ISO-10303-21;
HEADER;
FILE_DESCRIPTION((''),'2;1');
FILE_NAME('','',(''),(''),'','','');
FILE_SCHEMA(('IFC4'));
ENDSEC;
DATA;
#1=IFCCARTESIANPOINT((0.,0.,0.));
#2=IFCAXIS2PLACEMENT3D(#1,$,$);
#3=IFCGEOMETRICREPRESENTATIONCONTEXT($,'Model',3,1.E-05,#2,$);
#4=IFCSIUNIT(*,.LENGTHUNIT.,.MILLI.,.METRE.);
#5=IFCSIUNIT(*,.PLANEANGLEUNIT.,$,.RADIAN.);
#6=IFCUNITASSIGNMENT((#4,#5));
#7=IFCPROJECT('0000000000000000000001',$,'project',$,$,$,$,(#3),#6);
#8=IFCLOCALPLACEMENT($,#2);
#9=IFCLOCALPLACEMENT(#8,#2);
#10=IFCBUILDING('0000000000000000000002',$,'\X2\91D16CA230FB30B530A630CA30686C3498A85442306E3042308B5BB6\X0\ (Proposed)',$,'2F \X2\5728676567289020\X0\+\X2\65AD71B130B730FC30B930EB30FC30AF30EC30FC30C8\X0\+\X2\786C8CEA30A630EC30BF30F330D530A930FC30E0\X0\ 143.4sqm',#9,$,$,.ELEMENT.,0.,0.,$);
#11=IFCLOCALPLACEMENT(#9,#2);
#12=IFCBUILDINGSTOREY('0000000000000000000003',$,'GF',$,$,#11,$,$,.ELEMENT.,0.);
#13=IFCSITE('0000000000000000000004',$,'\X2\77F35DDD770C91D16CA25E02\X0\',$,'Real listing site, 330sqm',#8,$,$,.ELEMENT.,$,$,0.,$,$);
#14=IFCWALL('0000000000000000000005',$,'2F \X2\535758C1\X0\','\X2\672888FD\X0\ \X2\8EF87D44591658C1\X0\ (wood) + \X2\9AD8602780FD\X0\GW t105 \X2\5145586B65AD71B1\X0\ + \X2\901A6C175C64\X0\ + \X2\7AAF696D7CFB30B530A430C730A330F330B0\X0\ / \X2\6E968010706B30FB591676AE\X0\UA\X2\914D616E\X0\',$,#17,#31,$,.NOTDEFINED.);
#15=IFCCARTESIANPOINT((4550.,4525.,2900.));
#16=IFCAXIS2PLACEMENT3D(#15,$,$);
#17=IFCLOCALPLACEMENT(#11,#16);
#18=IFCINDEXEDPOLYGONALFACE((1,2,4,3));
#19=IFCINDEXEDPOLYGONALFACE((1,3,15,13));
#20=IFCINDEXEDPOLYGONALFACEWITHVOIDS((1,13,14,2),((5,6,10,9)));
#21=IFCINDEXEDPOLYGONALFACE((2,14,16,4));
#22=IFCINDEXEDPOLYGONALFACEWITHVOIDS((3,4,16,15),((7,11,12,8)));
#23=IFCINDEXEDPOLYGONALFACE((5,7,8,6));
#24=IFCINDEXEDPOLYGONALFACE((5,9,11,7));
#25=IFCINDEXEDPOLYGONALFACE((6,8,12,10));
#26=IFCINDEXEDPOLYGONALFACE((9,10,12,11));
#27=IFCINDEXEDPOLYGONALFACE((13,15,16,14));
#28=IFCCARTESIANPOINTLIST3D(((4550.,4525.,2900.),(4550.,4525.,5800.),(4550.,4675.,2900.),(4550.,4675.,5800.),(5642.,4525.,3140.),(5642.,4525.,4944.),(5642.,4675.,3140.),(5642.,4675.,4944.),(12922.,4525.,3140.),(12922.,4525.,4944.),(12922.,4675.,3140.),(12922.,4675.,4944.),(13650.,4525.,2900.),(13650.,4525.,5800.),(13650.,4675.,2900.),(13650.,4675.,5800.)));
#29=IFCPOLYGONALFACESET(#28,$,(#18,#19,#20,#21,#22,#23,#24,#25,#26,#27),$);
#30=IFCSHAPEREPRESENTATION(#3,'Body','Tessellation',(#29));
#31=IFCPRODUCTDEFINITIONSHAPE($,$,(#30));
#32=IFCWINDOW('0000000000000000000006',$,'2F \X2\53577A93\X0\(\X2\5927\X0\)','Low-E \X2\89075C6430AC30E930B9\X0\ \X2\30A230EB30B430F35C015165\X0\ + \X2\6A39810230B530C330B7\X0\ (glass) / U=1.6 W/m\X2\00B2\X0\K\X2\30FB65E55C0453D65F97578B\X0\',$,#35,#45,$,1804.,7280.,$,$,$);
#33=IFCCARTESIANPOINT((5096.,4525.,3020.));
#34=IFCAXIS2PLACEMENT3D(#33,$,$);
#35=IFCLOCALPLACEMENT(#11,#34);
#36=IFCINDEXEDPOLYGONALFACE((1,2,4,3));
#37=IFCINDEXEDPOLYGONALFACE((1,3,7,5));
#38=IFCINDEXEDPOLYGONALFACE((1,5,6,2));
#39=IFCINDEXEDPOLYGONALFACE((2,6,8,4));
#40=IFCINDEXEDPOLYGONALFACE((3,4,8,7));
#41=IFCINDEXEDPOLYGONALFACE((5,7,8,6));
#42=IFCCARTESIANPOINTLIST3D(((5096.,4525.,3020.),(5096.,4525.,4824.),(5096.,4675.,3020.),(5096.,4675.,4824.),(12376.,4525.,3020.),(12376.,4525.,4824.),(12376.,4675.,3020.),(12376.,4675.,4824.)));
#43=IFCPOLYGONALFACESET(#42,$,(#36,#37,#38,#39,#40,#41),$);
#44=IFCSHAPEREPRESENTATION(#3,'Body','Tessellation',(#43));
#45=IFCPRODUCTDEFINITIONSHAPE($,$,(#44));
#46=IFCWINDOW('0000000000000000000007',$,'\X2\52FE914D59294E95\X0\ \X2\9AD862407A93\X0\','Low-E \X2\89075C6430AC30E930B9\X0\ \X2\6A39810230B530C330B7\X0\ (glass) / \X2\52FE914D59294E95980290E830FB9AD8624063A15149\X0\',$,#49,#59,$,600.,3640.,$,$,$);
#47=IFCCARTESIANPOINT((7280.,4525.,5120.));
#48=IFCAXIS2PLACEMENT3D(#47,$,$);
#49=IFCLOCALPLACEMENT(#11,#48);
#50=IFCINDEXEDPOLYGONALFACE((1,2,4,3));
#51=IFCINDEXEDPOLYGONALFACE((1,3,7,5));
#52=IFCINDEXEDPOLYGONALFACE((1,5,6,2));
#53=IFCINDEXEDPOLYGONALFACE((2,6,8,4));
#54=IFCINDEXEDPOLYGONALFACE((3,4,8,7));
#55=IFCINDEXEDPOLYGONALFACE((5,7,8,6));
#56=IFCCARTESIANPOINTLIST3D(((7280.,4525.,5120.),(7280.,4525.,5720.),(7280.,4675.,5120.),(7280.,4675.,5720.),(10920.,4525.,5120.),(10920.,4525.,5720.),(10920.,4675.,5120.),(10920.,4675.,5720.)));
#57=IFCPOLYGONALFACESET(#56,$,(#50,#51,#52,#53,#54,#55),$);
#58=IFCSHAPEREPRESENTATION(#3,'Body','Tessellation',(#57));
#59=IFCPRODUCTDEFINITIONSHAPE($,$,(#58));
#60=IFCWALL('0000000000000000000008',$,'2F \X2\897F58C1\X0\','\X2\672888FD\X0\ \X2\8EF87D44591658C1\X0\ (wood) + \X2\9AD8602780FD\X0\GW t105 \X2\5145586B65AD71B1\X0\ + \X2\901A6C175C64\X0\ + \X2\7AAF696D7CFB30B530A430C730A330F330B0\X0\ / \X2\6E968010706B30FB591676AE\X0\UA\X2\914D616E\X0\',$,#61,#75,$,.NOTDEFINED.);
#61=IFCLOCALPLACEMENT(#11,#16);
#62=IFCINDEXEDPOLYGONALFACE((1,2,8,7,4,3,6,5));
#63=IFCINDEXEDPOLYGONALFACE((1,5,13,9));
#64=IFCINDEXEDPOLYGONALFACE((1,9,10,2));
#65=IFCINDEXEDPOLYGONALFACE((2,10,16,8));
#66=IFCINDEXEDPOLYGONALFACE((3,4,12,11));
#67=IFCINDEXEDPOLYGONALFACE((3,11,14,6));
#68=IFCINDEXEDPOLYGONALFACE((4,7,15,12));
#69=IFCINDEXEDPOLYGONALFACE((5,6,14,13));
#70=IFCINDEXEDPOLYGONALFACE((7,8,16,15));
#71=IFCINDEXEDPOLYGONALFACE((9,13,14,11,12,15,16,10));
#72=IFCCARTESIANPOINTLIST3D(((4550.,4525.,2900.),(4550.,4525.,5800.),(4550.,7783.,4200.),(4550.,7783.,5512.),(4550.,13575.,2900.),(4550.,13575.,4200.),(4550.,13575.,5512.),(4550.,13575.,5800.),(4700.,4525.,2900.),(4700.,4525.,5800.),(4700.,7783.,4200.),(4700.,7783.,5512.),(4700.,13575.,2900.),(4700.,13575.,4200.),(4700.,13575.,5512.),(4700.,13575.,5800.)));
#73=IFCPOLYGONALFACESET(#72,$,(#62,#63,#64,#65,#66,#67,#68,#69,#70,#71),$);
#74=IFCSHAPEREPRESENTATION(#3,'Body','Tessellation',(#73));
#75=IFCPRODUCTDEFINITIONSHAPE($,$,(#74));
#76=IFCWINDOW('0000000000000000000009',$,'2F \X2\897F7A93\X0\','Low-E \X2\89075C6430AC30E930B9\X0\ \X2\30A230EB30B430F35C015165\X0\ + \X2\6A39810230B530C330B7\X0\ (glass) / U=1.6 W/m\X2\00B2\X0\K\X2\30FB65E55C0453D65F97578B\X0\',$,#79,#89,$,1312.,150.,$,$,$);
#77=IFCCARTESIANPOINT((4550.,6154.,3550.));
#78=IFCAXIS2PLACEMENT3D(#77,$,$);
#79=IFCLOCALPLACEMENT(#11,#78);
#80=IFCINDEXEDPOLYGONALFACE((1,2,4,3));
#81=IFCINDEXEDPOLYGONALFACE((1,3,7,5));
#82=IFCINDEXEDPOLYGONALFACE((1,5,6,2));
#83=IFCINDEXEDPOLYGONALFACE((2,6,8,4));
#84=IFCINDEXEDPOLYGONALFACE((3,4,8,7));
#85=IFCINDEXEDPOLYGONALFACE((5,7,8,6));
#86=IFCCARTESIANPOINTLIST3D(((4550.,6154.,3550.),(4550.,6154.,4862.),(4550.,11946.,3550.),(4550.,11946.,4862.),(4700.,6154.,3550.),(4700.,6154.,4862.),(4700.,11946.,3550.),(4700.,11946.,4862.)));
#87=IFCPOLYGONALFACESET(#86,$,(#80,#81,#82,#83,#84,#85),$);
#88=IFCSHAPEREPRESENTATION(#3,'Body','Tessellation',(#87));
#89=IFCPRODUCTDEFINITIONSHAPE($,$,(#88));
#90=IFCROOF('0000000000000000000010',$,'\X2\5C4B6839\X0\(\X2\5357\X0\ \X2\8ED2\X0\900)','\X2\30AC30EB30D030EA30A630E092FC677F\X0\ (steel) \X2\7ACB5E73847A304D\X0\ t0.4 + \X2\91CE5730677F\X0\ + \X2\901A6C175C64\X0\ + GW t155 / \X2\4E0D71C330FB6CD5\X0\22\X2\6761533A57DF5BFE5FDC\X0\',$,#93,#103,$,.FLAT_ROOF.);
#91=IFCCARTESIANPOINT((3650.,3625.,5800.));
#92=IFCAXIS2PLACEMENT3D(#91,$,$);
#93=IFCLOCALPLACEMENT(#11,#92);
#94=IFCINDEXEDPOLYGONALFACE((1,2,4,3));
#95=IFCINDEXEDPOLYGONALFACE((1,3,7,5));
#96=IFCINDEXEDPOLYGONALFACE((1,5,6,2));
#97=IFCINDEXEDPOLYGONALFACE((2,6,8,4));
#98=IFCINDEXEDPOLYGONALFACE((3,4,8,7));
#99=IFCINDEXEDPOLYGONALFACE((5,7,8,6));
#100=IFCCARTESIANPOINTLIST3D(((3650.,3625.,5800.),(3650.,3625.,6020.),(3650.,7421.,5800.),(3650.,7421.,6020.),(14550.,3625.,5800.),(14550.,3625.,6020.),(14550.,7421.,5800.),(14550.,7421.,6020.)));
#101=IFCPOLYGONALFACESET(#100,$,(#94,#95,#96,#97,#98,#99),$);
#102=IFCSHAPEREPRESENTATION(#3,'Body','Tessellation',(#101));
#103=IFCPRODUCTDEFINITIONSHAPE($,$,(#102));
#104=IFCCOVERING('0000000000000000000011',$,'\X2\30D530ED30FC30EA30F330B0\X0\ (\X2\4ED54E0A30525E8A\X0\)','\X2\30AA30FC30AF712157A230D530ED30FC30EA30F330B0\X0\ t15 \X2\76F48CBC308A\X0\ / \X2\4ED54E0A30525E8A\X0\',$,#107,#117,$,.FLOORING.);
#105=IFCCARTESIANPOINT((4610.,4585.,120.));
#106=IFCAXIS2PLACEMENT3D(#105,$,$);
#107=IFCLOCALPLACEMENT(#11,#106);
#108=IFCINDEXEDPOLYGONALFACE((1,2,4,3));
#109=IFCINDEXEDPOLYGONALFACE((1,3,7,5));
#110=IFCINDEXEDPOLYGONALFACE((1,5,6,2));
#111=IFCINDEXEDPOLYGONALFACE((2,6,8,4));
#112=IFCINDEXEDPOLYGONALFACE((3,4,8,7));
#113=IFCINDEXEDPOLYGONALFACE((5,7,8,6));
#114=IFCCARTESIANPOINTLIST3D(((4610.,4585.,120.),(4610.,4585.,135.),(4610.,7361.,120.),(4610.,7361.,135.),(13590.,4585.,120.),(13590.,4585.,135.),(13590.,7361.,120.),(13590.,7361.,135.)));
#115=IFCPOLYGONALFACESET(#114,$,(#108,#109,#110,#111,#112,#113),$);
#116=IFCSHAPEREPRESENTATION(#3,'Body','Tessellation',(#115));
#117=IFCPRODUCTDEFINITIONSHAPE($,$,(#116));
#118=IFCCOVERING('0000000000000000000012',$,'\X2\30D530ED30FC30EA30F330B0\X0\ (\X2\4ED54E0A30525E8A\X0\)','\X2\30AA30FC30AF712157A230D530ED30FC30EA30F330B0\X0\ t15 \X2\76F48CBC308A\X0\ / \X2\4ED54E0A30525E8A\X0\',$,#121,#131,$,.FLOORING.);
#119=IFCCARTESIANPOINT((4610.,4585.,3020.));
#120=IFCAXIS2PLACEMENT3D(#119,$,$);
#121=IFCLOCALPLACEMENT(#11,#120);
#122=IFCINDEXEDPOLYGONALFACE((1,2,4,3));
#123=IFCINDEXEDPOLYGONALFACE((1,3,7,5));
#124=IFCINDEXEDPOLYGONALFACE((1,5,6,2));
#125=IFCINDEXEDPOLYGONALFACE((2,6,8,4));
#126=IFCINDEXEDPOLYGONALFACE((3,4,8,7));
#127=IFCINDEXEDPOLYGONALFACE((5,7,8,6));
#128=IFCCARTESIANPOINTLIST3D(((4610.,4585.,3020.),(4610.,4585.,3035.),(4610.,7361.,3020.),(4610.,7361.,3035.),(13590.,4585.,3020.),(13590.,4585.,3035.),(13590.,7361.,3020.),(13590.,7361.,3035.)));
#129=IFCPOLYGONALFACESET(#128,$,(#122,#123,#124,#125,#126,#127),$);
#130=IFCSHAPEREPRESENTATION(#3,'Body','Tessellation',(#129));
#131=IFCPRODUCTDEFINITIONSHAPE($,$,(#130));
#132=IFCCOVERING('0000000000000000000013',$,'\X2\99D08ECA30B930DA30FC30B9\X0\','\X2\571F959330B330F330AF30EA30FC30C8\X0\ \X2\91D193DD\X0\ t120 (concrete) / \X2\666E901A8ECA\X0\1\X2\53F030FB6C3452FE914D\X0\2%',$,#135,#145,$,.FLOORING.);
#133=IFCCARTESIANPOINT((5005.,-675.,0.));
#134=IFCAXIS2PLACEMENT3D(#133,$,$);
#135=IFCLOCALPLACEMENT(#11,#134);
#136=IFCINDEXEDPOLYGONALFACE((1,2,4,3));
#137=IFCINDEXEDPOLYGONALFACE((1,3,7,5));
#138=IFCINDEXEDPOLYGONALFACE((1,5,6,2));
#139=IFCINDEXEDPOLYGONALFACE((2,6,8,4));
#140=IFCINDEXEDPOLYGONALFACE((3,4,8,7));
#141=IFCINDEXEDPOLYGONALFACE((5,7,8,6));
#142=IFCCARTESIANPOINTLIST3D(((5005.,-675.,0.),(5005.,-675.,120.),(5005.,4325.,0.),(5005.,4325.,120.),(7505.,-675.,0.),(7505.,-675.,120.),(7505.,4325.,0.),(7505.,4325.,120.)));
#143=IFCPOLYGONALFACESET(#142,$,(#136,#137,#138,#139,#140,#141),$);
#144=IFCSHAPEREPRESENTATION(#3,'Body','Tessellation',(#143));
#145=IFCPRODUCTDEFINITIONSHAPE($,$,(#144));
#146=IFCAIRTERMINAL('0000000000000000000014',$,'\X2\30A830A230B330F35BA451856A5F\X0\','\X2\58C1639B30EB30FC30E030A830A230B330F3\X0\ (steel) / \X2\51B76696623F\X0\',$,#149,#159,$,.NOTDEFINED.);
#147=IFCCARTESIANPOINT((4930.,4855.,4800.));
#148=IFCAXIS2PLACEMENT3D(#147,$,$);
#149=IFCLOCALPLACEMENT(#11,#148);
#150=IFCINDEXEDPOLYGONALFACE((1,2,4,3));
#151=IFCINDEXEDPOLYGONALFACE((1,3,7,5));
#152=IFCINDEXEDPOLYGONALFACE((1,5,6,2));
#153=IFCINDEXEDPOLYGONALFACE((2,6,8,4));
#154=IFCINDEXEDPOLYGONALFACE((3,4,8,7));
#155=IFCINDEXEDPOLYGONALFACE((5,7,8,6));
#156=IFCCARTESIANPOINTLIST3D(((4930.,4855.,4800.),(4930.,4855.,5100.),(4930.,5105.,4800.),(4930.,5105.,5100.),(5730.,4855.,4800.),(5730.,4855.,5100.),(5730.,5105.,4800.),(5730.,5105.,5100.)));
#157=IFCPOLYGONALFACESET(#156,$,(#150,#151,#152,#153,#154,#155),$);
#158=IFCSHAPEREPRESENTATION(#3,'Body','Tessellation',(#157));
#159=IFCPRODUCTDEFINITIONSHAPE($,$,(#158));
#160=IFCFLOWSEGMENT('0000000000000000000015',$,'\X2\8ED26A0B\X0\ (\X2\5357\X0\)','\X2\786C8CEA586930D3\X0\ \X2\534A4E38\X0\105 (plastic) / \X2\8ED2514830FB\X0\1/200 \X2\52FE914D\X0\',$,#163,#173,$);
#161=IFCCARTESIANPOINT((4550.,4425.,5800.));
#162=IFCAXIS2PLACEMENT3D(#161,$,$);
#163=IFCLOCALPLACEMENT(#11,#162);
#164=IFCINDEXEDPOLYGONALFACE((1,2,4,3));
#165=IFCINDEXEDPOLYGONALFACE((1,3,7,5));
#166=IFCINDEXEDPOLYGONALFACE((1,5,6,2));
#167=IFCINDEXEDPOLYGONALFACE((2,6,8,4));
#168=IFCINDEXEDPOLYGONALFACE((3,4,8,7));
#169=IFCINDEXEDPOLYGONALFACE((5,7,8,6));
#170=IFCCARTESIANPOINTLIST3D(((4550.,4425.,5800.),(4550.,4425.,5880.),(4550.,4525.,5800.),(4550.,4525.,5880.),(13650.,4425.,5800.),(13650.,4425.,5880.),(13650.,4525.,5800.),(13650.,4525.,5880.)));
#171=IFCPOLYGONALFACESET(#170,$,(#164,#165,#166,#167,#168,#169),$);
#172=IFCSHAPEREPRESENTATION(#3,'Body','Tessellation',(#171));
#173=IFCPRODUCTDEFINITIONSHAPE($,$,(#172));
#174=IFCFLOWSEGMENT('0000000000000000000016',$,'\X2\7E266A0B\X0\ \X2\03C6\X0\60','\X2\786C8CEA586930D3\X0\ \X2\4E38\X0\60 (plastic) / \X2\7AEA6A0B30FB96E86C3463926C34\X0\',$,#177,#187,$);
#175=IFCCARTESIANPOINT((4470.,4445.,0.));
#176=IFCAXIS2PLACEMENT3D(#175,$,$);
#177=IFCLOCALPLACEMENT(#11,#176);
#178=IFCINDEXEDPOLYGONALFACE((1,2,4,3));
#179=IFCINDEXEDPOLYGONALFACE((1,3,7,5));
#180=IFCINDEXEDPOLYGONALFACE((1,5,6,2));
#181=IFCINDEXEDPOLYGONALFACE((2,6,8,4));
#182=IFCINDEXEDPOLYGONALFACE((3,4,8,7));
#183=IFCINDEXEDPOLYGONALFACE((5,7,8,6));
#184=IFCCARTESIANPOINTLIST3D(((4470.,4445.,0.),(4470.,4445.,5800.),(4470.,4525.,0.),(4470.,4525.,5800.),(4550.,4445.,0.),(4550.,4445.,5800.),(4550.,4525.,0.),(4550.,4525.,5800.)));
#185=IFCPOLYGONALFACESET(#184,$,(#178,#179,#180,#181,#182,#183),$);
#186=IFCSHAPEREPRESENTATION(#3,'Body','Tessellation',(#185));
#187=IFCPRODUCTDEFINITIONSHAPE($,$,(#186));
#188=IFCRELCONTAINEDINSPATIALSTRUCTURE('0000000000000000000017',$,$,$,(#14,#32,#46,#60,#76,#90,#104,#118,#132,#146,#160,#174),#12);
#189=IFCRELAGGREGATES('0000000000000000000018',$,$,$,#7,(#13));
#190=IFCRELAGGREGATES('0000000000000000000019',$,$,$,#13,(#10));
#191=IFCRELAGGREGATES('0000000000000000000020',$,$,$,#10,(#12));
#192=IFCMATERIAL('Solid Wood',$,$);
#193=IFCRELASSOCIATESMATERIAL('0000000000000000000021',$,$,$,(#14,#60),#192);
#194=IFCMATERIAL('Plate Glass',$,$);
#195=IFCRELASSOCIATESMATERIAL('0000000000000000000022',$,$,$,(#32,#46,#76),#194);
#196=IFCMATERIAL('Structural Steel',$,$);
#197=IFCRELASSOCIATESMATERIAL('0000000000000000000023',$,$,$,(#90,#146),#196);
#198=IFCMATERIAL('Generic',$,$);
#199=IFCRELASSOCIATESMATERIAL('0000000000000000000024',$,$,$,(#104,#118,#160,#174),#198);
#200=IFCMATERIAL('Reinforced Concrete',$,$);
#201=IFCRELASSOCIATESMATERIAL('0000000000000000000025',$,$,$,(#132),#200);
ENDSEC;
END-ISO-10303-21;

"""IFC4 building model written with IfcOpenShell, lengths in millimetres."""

from ifc_helpers import new_model, si_unit, frame, frame_2d, origin, place, context, project, spatial, rectangle, extrude, material, element, fill, save


model = new_model("IFC4")

# Units and contexts
model_context = context("Model", 3, precision=1e-05, world=origin())
ifc_project = project(units=[si_unit("LENGTHUNIT", "METRE", prefix="MILLI"), si_unit("PLANEANGLEUNIT", "RADIAN")], contexts=[model_context])

# Site, building, storey
site_placement = place(None, origin())
site = spatial("IfcSite", under=ifc_project, at=site_placement, Name="石川県金沢市", ObjectType="Real listing site, 330sqm", CompositionType="ELEMENT", RefElevation=0.0)
building_placement = place(site_placement, origin())
building = spatial("IfcBuilding", under=site, at=building_placement, Name="金沢・サウナと水風呂のある家 (Proposed)", ObjectType="2F 在来木造+断熱シースルークレート+硬質ウレタンフォーム 143.4sqm", CompositionType="ELEMENT", ElevationOfRefHeight=0.0, ElevationOfTerrain=0.0)
storey_placement = place(building_placement, origin())
storey = spatial("IfcBuildingStorey", under=building, at=storey_placement, Name="GF", CompositionType="ELEMENT", Elevation=0.0)

# Shared definitions
ifc_material_1 = material(Name="Solid Wood")

# Shared definitions
ifc_material_2 = material(Name="Reinforced Concrete")

# Shared definitions
ifc_material_3 = material(Name="Plate Glass")

# Wall, openings, windows
wall_1_placement = place(storey_placement, frame((4550.0, 4525.0, 2900.0)))
wall_1 = element("IfcWall", 1, at=wall_1_placement, inside=storey, material=ifc_material_1, Name="2F 南壁", Description="木製 軸組外壁 (wood) + 高性能GW t105 充填断熱 + 通気層 + 窯業系サイディング / 準耐火・外皮UA配慮", PredefinedType="NOTDEFINED", context=model_context, shape_type="SweptSolid", body=[
    extrude(rectangle(XDim=9100.0, YDim=150.0, at=frame_2d((4550.0, 75.0))), frame((4550.0, 4525.0, 2900.0)), (0.0, 0.0, 1.0), 2900.0),
])
opening_1_placement = place(storey_placement, frame((5096.0, 4525.0, 3020.0)))
opening_1 = element("IfcOpeningElement", 2, at=opening_1_placement, cuts=wall_1, PredefinedType="NOTDEFINED", context=model_context, shape_type="SweptSolid", body=[
    extrude(rectangle(XDim=7280.0, YDim=150.0, at=frame_2d((3640.0, 75.0))), frame((5096.0, 4525.0, 3020.0)), (0.0, 0.0, 1.0), 1804.0),
])
opening_2_placement = place(storey_placement, frame((7280.0, 4525.0, 5120.0)))
opening_2 = element("IfcOpeningElement", 3, at=opening_2_placement, cuts=wall_1, PredefinedType="NOTDEFINED", context=model_context, shape_type="SweptSolid", body=[
    extrude(rectangle(XDim=3640.0, YDim=150.0, at=frame_2d((1820.0, 75.0))), frame((7280.0, 4525.0, 5120.0)), (0.0, 0.0, 1.0), 600.0),
])
window_1_placement = place(storey_placement, frame((5096.0, 4525.0, 3020.0)))
window_1 = element("IfcWindow", 4, at=window_1_placement, inside=storey, material=ifc_material_3, Name="2F 南窓(大)", Description="Low-E 複層ガラス アルゴン封入 + 樹脂サッシ (glass) / U=1.6 W/m²K・日射取得型", OverallHeight=1804.0, OverallWidth=7280.0, context=model_context, shape_type="SweptSolid", body=[
    extrude(rectangle(XDim=7280.0, YDim=150.0, at=frame_2d((3640.0, 75.0))), frame((5096.0, 4525.0, 3020.0)), (0.0, 0.0, 1.0), 1804.0),
])
fill(opening_1, window_1)
window_2_placement = place(storey_placement, frame((7280.0, 4525.0, 5120.0)))
window_2 = element("IfcWindow", 5, at=window_2_placement, inside=storey, material=ifc_material_3, Name="勾配天井 高所窓", Description="Low-E 複層ガラス 樹脂サッシ (glass) / 勾配天井頂部・高所採光", OverallHeight=600.0, OverallWidth=3640.0, context=model_context, shape_type="SweptSolid", body=[
    extrude(rectangle(XDim=3640.0, YDim=150.0, at=frame_2d((1820.0, 75.0))), frame((7280.0, 4525.0, 5120.0)), (0.0, 0.0, 1.0), 600.0),
])
fill(opening_2, window_2)

# Wall, opening, window
wall_2_placement = place(storey_placement, frame((4550.0, 4525.0, 2900.0)))
wall_2 = element("IfcWall", 6, at=wall_2_placement, inside=storey, material=ifc_material_1, Name="2F 西壁", Description="木製 軸組外壁 (wood) + 高性能GW t105 充填断熱 + 通気層 + 窯業系サイディング / 準耐火・外皮UA配慮", PredefinedType="NOTDEFINED", context=model_context, shape_type="SweptSolid", body=[
    extrude(rectangle(XDim=150.0, YDim=9050.0, at=frame_2d((75.0, 4525.0))), frame((4550.0, 4525.0, 2900.0)), (0.0, 0.0, 1.0), 2900.0),
])
opening_3_placement = place(storey_placement, frame((4550.0, 6154.0, 3550.0)))
opening_3 = element("IfcOpeningElement", 7, at=opening_3_placement, cuts=wall_2, PredefinedType="NOTDEFINED", context=model_context, shape_type="SweptSolid", body=[
    extrude(rectangle(XDim=150.0, YDim=5792.0, at=frame_2d((75.0, 2896.0))), frame((4550.0, 6154.0, 3550.0)), (0.0, 0.0, 1.0), 1312.0),
])
window_3_placement = place(storey_placement, frame((4550.0, 6154.0, 3550.0)))
window_3 = element("IfcWindow", 8, at=window_3_placement, inside=storey, material=ifc_material_3, Name="2F 西窓", Description="Low-E 複層ガラス アルゴン封入 + 樹脂サッシ (glass) / U=1.6 W/m²K・日射取得型", OverallHeight=1312.0, OverallWidth=150.0, context=model_context, shape_type="SweptSolid", body=[
    extrude(rectangle(XDim=150.0, YDim=5792.0, at=frame_2d((75.0, 2896.0))), frame((4550.0, 6154.0, 3550.0)), (0.0, 0.0, 1.0), 1312.0),
])
fill(opening_3, window_3)

# Roof
ifc_material_4 = material(Name="Structural Steel")
for number, where, name in (
    (9, (3650.0, 3625.0, 5800.0), "屋根(南 軒900)"),
):
    element("IfcRoof", number, at=place(storey_placement, frame(where)), inside=storey, material=ifc_material_4, Name=name, Description="ガルバリウム鋼板 (steel) 立平葺き t0.4 + 野地板 + 通気層 + GW t155 / 不燃・法22条区域対応", PredefinedType="FLAT_ROOF", context=model_context, shape_type="SweptSolid", body=[
        extrude(rectangle(XDim=10900.0, YDim=3796.0, at=frame_2d((5450.0, 1898.0))), frame((3650.0, 3625.0, 5800.0)), (0.0, 0.0, 1.0), 220.0),
    ])

# Coverings
ifc_material_5 = material(Name="Generic")
covering_1_placement = place(storey_placement, frame((4610.0, 4585.0, 120.0)))
element("IfcCovering", 10, at=covering_1_placement, inside=storey, material=ifc_material_5, Name="フローリング (仕上げ床)", Description="オーク無垢フローリング t15 直貼り / 仕上げ床", PredefinedType="FLOORING", context=model_context, shape_type="SweptSolid", body=[
    extrude(rectangle(XDim=8980.0, YDim=2776.0, at=frame_2d((4490.0, 1388.0))), frame((4610.0, 4585.0, 120.0)), (0.0, 0.0, 1.0), 15.0),
])
covering_2_placement = place(storey_placement, frame((4610.0, 4585.0, 3020.0)))
element("IfcCovering", 11, at=covering_2_placement, inside=storey, material=ifc_material_5, Name="フローリング (仕上げ床)", Description="オーク無垢フローリング t15 直貼り / 仕上げ床", PredefinedType="FLOORING", context=model_context, shape_type="SweptSolid", body=[
    extrude(rectangle(XDim=8980.0, YDim=2776.0, at=frame_2d((4490.0, 1388.0))), frame((4610.0, 4585.0, 3020.0)), (0.0, 0.0, 1.0), 15.0),
])
covering_3_placement = place(storey_placement, frame((5005.0, -675.0, 0.0)))
element("IfcCovering", 12, at=covering_3_placement, inside=storey, material=ifc_material_2, Name="駐車スペース", Description="土間コンクリート 金鏝 t120 (concrete) / 普通車1台・水勾配2%", PredefinedType="FLOORING", context=model_context, shape_type="SweptSolid", body=[
    extrude(rectangle(XDim=2500.0, YDim=5000.0, at=frame_2d((1250.0, 2500.0))), frame((5005.0, -675.0, 0.0)), (0.0, 0.0, 1.0), 120.0),
])

# Air terminal
air_terminal_placement = place(storey_placement, frame((4930.0, 4855.0, 4800.0)))
element("IfcAirTerminal", 13, at=air_terminal_placement, inside=storey, material=ifc_material_4, Name="エアコン室内機", Description="壁掛ルームエアコン (steel) / 冷暖房", PredefinedType="NOTDEFINED", context=model_context, shape_type="SweptSolid", body=[
    extrude(rectangle(XDim=800.0, YDim=250.0, at=frame_2d((400.0, 125.0))), frame((4930.0, 4855.0, 4800.0)), (0.0, 0.0, 1.0), 300.0),
])

# Flow segments
flow_segment_1_placement = place(storey_placement, frame((4550.0, 4425.0, 5800.0)))
element("IfcFlowSegment", 14, at=flow_segment_1_placement, inside=storey, material=ifc_material_5, Name="軒樋 (南)", Description="硬質塩ビ 半丸105 (plastic) / 軒先・1/200 勾配", context=model_context, shape_type="SweptSolid", body=[
    extrude(rectangle(XDim=9100.0, YDim=100.0, at=frame_2d((4550.0, 50.0))), frame((4550.0, 4425.0, 5800.0)), (0.0, 0.0, 1.0), 80.0),
])
flow_segment_2_placement = place(storey_placement, frame((4470.0, 4445.0, 0.0)))
element("IfcFlowSegment", 15, at=flow_segment_2_placement, inside=storey, material=ifc_material_5, Name="縦樋 φ60", Description="硬質塩ビ 丸60 (plastic) / 竪樋・雨水排水", context=model_context, shape_type="SweptSolid", body=[
    extrude(rectangle(XDim=80.0, YDim=80.0, at=frame_2d((40.0, 40.0))), frame((4470.0, 4445.0, 0.0)), (0.0, 0.0, 1.0), 5800.0),
])

save(model, "model.ifc")
